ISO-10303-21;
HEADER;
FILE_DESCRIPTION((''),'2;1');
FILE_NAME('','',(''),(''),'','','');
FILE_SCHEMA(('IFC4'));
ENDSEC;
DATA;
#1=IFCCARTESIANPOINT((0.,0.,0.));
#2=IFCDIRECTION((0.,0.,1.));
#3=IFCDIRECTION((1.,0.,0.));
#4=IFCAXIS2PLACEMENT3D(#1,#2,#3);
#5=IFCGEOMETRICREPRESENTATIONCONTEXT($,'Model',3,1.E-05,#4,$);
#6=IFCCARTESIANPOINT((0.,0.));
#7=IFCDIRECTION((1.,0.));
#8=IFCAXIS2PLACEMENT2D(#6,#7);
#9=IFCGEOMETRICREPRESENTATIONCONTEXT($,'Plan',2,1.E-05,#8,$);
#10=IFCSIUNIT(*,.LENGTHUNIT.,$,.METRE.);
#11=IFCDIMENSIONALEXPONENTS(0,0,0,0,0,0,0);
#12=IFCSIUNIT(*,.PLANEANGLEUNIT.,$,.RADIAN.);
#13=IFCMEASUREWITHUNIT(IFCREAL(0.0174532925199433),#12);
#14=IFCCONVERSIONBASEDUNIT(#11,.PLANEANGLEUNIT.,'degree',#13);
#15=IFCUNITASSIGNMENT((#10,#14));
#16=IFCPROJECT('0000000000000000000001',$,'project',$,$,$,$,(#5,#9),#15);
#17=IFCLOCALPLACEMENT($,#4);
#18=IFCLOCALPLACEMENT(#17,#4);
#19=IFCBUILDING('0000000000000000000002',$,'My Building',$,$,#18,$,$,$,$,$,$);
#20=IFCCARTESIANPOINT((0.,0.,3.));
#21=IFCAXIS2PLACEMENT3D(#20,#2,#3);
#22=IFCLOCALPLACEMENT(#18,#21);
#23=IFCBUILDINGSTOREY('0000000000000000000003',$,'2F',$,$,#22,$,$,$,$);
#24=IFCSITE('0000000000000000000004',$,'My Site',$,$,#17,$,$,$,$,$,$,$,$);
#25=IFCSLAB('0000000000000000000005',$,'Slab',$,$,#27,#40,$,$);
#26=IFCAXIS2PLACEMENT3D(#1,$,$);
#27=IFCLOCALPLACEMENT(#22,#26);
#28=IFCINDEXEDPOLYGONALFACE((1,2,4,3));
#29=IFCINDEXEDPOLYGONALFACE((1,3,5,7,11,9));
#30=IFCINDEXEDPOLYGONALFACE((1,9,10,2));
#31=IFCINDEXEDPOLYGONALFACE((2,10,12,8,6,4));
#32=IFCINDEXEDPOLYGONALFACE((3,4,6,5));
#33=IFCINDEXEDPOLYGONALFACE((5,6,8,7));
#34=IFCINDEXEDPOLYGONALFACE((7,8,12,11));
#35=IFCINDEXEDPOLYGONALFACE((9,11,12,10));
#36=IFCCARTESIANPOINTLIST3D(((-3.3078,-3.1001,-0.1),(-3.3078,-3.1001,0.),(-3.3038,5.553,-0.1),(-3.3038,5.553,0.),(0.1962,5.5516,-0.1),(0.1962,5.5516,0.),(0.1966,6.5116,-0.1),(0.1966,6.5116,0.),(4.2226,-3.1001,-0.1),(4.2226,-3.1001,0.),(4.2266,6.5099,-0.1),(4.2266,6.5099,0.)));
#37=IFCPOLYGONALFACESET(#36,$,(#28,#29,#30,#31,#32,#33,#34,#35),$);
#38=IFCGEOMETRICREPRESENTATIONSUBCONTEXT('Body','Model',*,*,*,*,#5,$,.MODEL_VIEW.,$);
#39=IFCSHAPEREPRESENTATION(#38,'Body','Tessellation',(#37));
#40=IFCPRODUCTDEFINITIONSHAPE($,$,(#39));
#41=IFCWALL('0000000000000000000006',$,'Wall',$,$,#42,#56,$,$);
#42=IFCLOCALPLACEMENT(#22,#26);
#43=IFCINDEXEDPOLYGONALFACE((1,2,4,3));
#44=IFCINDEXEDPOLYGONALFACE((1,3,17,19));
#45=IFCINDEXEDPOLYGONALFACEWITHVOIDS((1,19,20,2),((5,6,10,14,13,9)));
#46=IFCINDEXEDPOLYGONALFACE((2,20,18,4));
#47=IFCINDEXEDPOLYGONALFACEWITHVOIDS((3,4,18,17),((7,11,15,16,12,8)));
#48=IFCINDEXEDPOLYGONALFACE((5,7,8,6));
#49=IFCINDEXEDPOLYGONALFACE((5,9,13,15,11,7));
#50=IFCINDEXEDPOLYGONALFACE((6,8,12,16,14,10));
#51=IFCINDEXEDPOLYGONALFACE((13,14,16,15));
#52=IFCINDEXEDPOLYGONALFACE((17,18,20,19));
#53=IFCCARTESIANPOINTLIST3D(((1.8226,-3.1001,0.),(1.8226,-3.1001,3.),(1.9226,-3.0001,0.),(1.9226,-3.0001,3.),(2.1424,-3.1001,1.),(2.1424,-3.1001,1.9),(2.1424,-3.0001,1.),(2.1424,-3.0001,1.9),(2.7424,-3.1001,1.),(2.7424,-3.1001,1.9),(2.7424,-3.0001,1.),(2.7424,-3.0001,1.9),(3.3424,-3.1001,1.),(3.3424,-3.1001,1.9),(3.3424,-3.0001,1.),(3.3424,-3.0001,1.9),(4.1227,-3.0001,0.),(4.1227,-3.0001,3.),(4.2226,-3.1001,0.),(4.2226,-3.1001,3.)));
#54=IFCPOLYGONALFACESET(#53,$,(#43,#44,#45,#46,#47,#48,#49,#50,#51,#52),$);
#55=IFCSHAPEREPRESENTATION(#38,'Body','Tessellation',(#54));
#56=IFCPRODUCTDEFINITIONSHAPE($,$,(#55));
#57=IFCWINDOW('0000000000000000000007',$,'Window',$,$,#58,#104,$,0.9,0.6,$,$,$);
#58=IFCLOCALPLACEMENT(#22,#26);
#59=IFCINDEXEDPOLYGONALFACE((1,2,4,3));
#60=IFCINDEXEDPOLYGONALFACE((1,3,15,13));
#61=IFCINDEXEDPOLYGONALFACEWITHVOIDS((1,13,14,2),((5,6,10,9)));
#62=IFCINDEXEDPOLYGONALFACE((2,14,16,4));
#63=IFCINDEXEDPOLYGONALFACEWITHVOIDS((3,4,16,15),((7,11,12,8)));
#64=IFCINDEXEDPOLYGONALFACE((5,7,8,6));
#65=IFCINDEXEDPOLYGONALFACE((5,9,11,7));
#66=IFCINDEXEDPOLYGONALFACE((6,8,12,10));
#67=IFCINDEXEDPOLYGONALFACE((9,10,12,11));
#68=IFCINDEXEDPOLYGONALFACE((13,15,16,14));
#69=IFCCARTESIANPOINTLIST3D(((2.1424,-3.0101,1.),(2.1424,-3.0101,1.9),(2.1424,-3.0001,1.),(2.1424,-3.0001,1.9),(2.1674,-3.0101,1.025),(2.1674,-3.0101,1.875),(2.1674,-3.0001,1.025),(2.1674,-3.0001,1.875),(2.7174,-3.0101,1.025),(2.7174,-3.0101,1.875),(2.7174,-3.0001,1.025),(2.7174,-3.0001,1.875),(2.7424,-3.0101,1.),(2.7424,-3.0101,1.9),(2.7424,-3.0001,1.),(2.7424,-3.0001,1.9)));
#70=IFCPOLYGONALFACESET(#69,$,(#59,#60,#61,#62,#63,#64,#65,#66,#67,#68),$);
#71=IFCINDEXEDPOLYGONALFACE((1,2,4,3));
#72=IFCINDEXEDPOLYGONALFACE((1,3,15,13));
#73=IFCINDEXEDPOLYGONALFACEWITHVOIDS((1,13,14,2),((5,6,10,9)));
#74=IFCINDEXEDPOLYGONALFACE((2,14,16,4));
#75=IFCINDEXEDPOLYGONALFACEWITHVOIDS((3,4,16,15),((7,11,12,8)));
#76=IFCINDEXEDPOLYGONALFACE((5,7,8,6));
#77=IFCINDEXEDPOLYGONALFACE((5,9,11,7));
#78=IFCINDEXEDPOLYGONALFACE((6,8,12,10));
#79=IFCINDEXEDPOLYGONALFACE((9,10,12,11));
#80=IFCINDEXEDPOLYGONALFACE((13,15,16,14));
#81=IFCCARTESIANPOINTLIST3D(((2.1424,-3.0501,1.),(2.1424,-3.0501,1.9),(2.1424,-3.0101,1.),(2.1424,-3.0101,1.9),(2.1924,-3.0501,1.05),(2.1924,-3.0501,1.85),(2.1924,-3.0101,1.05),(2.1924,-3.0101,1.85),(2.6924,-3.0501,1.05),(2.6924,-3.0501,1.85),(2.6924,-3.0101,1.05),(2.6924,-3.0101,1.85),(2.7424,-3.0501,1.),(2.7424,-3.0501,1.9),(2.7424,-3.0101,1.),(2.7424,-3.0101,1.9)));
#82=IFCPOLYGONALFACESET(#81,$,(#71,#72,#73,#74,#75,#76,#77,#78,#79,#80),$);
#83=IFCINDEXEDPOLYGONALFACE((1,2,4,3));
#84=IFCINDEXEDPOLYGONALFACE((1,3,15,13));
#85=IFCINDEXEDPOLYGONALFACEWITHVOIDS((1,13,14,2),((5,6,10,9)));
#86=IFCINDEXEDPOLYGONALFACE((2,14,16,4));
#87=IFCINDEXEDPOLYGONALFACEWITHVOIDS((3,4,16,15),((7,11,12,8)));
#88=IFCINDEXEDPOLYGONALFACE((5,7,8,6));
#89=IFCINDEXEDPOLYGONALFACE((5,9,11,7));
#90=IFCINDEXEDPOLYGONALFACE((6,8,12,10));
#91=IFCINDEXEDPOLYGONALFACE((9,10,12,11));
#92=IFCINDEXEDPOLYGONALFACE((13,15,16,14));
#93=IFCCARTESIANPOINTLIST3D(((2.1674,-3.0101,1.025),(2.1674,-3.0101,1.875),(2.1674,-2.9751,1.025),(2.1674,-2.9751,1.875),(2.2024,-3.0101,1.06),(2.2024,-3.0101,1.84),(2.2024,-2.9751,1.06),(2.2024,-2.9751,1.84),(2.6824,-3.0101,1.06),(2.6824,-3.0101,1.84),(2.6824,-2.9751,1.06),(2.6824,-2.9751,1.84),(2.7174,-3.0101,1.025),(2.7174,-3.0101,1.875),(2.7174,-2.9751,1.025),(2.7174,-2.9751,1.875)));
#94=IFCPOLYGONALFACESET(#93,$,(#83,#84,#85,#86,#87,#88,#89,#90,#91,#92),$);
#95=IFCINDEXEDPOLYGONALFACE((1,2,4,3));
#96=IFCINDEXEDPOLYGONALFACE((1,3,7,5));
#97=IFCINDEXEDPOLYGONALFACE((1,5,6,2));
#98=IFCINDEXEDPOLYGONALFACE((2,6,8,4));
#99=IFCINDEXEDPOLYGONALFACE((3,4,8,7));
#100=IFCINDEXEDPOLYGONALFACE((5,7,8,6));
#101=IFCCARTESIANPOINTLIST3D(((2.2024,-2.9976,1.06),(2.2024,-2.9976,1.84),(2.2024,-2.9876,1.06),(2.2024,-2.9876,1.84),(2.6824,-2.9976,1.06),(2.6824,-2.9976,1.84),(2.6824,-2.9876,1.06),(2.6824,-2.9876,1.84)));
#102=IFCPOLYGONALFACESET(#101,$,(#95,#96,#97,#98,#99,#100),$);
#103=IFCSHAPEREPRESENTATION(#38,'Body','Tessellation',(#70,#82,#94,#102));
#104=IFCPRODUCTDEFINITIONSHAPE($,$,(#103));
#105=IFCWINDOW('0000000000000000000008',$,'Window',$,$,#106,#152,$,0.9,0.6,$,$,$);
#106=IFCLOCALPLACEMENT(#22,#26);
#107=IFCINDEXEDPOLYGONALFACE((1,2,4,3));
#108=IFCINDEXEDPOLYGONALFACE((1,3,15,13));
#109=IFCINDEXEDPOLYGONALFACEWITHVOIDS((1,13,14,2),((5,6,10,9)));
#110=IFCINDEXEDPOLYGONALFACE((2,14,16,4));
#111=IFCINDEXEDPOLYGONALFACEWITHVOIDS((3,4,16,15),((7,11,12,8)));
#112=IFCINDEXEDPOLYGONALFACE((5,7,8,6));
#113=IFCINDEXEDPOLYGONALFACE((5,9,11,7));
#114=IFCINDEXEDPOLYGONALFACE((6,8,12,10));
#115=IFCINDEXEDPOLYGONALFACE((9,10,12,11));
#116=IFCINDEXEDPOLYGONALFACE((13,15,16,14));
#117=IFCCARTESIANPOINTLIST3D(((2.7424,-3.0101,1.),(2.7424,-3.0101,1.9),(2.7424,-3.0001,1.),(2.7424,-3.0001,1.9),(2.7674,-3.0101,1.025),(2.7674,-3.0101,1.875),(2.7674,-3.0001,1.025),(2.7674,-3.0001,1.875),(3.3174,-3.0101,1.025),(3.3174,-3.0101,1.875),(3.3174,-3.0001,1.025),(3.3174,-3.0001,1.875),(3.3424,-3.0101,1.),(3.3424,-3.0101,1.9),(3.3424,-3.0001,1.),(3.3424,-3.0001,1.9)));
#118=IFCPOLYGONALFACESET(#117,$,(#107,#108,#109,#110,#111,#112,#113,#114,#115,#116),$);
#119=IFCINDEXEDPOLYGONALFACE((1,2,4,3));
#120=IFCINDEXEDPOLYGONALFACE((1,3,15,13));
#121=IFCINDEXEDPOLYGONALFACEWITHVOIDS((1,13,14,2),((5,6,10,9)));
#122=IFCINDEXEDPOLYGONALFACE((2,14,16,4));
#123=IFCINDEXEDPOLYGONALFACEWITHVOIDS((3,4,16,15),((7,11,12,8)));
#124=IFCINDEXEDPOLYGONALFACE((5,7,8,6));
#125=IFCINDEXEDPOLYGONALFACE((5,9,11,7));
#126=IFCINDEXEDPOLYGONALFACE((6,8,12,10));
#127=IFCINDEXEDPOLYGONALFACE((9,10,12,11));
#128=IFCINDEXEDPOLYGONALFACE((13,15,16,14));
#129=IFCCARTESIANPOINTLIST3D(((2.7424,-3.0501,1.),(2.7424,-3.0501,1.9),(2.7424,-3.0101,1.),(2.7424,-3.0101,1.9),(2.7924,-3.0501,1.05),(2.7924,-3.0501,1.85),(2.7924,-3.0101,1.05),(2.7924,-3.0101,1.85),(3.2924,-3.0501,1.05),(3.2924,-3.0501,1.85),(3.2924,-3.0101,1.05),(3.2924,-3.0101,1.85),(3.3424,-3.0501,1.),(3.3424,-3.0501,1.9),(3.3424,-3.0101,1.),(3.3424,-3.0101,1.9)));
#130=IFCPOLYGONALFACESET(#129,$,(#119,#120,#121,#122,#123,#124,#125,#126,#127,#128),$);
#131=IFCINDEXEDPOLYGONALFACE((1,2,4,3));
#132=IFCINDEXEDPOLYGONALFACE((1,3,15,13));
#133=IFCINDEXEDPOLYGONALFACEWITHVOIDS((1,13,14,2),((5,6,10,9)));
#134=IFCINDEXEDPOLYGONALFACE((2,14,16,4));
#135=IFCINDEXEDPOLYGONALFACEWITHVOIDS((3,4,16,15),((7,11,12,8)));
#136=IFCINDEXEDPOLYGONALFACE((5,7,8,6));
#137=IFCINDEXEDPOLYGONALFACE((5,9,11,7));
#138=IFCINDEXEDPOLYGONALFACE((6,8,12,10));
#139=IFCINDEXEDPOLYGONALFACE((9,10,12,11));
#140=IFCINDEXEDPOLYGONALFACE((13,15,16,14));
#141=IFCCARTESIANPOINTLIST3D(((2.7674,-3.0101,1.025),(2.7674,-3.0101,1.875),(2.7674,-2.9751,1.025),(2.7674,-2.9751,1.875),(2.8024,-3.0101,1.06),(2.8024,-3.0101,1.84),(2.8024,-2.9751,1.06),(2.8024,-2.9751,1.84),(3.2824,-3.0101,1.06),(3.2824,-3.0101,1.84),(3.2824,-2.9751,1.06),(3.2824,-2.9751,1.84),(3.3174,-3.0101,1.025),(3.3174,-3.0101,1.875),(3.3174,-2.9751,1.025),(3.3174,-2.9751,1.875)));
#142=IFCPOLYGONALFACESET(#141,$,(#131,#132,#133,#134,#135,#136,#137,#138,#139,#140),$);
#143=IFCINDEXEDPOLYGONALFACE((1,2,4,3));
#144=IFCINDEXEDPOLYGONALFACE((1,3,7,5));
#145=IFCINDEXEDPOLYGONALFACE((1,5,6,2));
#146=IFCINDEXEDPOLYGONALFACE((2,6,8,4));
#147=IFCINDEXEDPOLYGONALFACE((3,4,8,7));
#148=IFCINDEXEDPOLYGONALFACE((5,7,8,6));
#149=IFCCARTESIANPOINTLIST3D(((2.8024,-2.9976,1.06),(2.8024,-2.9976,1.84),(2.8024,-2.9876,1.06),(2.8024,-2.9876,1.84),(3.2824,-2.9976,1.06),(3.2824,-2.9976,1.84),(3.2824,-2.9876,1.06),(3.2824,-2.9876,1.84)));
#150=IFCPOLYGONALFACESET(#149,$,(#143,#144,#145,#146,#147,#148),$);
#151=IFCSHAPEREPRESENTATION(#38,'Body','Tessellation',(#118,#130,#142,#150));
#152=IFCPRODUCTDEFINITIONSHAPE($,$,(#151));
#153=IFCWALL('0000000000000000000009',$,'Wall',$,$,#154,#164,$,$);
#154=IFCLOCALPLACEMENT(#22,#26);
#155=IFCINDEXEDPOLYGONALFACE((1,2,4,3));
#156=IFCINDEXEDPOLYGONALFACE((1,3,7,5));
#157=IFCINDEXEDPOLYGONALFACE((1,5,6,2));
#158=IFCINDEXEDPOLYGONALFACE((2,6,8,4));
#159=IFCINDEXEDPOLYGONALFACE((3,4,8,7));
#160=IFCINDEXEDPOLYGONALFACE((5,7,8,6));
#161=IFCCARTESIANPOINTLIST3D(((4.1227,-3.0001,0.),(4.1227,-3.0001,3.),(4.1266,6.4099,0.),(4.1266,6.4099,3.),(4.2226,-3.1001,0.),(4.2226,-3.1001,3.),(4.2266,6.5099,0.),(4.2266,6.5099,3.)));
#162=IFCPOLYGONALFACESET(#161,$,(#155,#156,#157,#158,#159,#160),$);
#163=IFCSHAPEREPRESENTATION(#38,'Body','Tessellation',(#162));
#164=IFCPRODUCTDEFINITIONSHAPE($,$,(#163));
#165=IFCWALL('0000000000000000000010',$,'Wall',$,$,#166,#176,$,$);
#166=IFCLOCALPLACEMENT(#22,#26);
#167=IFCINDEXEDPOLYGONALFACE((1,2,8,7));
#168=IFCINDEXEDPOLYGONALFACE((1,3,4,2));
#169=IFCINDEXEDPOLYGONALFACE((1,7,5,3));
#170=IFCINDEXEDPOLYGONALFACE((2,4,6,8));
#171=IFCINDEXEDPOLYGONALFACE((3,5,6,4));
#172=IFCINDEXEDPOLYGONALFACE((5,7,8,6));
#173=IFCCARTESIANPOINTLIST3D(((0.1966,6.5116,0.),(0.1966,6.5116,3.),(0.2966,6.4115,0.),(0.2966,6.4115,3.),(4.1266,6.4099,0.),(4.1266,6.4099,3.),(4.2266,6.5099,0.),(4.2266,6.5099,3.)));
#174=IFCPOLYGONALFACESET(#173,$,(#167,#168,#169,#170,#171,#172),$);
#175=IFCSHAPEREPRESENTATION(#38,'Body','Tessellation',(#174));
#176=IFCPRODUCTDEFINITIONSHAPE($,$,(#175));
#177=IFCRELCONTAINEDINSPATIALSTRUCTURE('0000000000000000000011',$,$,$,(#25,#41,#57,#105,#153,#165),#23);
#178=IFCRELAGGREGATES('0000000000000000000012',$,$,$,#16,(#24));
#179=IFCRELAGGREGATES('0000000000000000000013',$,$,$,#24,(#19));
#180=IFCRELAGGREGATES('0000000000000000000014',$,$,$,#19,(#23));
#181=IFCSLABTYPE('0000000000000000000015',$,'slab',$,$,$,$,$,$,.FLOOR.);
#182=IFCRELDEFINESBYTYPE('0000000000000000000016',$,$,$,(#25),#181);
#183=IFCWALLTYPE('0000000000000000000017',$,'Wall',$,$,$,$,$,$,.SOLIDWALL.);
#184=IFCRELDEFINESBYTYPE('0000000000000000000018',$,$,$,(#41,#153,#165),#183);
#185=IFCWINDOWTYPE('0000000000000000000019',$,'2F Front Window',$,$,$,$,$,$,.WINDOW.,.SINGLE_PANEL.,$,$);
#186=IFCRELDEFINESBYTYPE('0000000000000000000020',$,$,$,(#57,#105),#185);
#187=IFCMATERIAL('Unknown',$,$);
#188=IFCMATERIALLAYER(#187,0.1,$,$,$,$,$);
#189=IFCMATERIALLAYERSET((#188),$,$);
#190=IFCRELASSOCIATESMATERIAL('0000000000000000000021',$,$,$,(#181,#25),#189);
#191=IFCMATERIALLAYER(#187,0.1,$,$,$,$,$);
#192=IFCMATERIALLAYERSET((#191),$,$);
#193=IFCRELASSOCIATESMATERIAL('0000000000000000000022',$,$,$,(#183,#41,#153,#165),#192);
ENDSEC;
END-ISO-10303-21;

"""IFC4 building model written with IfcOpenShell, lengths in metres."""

from ifc_helpers import new_model, entity, si_unit, converted_unit, frame, origin_with_axes, origin_2d_with_axis, place, context, subcontext, project, spatial, line, indexed_curve, outline, extrude, shape, source, transform, mapped, material, layer, layer_set, layer_usage, type_object, type_shapes, element, fill, save


model = new_model("IFC4")

# Units and contexts
model_context = context("Model", 3, precision=1e-05, world=origin_with_axes())
plan_context = context("Plan", 2, precision=1e-05, world=origin_2d_with_axis())
body_context_1 = subcontext(model_context, "Body", "Model", "MODEL_VIEW")
body_context_2 = subcontext(plan_context, "Body", "Plan", "PLAN_VIEW")
ifc_project = project(units=[si_unit("LENGTHUNIT", "METRE"), converted_unit("PLANEANGLEUNIT", "degree", entity("IfcReal", 0.0174532925199433), si_unit("PLANEANGLEUNIT", "RADIAN"), dimensions=[0, 0, 0, 0, 0, 0, 0])], contexts=[model_context, plan_context])

# Site, building, storey
site_placement = place(None, origin_with_axes())
site = spatial("IfcSite", under=ifc_project, at=site_placement, Name="My Site")
building_placement = place(site_placement, origin_with_axes())
building = spatial("IfcBuilding", under=site, at=building_placement, Name="My Building")
storey_placement = place(building_placement, frame((0.0, 0.0, 3.0), z_axis=(0.0, 0.0, 1.0), x_axis=(1.0, 0.0, 0.0)))
storey = spatial("IfcBuildingStorey", under=building, at=storey_placement, Name="2F")

# Slab
ifc_material = material(Name="Unknown")
ifc_layer_1 = layer(ifc_material, 0.1)
ifc_layer_set_1 = layer_set([ifc_layer_1])
ifc_layer_usage_1 = layer_usage(ifc_layer_set_1, "AXIS3", "POSITIVE", -0.1)
slab_type = type_object("IfcSlabType", Name="slab", PredefinedType="FLOOR", material=ifc_layer_set_1)
slab_placement = place(storey_placement, frame((-3.3078, -3.1001, 0.0), z_axis=(0.0, 0.0, 1.0), x_axis=(1.0, 0.0, 0.0)))
element("IfcSlab", 1, at=slab_placement, inside=storey, type_object=slab_type, material=ifc_layer_usage_1, Name="Slab", context=body_context_1, shape_type="SweptSolid", body=[
    extrude(outline(indexed_curve([(0.0, 0.0), (7.5304, 0.0), (7.5344, 9.61), (3.5044, 9.6117), (3.504, 8.6517), (0.004, 8.6531), (0.0, 0.0)])), frame((0.0, 0.0, -0.1), z_axis=(0.0, 0.0, 1.0), x_axis=(1.0, 0.0, 0.0)), (0.0, 0.0, 1.0), 0.1),
])

# Wall, openings, windows
ifc_layer_2 = layer(ifc_material, 0.1)
ifc_layer_set_2 = layer_set([ifc_layer_2])
ifc_layer_usage_2 = layer_usage(ifc_layer_set_2, "AXIS2", "POSITIVE", 0.0)
wall_type = type_object("IfcWallType", Name="Wall", PredefinedType="SOLIDWALL", material=ifc_layer_set_2)
wall_1_placement = place(storey_placement, frame((1.8226, -3.1001, 0.0), z_axis=(0.0, 0.0, 1.0), x_axis=(1.0, 0.0, 0.0)))
wall_1 = element("IfcWall", 2, at=wall_1_placement, inside=storey, type_object=wall_type, material=ifc_layer_usage_2, Name="Wall", context=body_context_1, shape_type="SweptSolid", body=[
    extrude(outline(indexed_curve([(0.0, 0.0), (0.1, 0.1), (2.3, 0.1), (2.4, 0.0)], segments=[line(1, 2, 3, 4, 1)])), origin_with_axes(), (0.0, 0.0, 1.0), 3.0),
])
shared_shape_1 = source(origin_with_axes(), body_context_1, "Body", "SweptSolid", [
    extrude(outline(indexed_curve([(0.0, 0.0), (0.6, 0.0), (0.6, 0.9), (0.0, 0.9)], segments=[line(1, 2, 3, 4, 1)])), frame((0.0, -0.6, 0.0), z_axis=(0.0, -1.0, 0.0), x_axis=(1.0, 0.0, 0.0)), (0.0, 0.0, -1.0), 1.2),
])
opening_1_placement = place(wall_1_placement, frame((0.3197, 0.0, 1.0), z_axis=(0.0, 0.0, 1.0), x_axis=(1.0, 0.0, 0.0)))
opening_1 = element("IfcOpeningElement", 3, at=opening_1_placement, cuts=wall_1, PredefinedType="OPENING", context=body_context_1, shape_type="MappedRepresentation", body=[
    mapped(shared_shape_1, transform((0.0, 0.0, 0.0), x_axis=(1.0, 0.0, 0.0), y_axis=(0.0, 1.0, 0.0), z_axis=(0.0, 0.0, 1.0), scale=1.0)),
])
opening_2_placement = place(wall_1_placement, frame((0.9197, 0.0, 1.0), z_axis=(0.0, 0.0, 1.0), x_axis=(1.0, 0.0, 0.0)))
opening_2 = element("IfcOpeningElement", 4, at=opening_2_placement, cuts=wall_1, PredefinedType="OPENING", context=body_context_1, shape_type="MappedRepresentation", body=[
    mapped(shared_shape_1, transform((0.0, 0.0, 0.0), x_axis=(1.0, 0.0, 0.0), y_axis=(0.0, 1.0, 0.0), z_axis=(0.0, 0.0, 1.0), scale=1.0)),
])
window_type_1 = type_object("IfcWindowType", Name="2F Front Window", PartitioningType="SINGLE_PANEL", PredefinedType="WINDOW")
shared_shape_2 = source(origin_with_axes(), body_context_1, "Body", "SweptSolid", [
    extrude(outline(indexed_curve([(0.0, 0.0), (0.6, 0.0), (0.6, 0.9), (0.0, 0.9)], segments=[line(1, 2, 3, 4, 1)]), holes=[indexed_curve([(0.025, 0.025), (0.575, 0.025), (0.575, 0.875), (0.025, 0.875)], segments=[line(1, 2, 3, 4, 1)])]), frame((0.0, 0.09, 0.0), z_axis=(0.0, -1.0, 0.0), x_axis=(1.0, 0.0, 0.0)), (0.0, 0.0, -1.0), 0.01),
    extrude(outline(indexed_curve([(0.0, 0.0), (0.6, 0.0), (0.6, 0.9), (0.0, 0.9)], segments=[line(1, 2, 3, 4, 1)]), holes=[indexed_curve([(0.05, 0.05), (0.55, 0.05), (0.55, 0.85), (0.05, 0.85)], segments=[line(1, 2, 3, 4, 1)])]), frame((0.0, 0.05, 0.0), z_axis=(0.0, -1.0, 0.0), x_axis=(1.0, 0.0, 0.0)), (0.0, 0.0, -1.0), 0.04),
    extrude(outline(indexed_curve([(0.0, 0.0), (0.55, 0.0), (0.55, 0.85), (0.0, 0.85)], segments=[line(1, 2, 3, 4, 1)]), holes=[indexed_curve([(0.035, 0.035), (0.515, 0.035), (0.515, 0.815), (0.035, 0.815)], segments=[line(1, 2, 3, 4, 1)])]), frame((0.025, 0.09, 0.025), z_axis=(0.0, -1.0, 0.0), x_axis=(1.0, 0.0, 0.0)), (0.0, 0.0, -1.0), 0.035),
    extrude(outline(indexed_curve([(0.035, 0.035), (0.515, 0.035), (0.515, 0.815), (0.035, 0.815)], segments=[line(1, 2, 3, 4, 1)])), frame((0.025, 0.1025, 0.025), z_axis=(0.0, -1.0, 0.0), x_axis=(1.0, 0.0, 0.0)), (0.0, 0.0, -1.0), 0.01),
])
shared_shape_3 = source(origin_with_axes(), body_context_2, "Body", "Curve2D", [
    entity("IfcIndexedPolyCurve", entity("IfcCartesianPointList2D", [[0.05, 0.05], [0.55, 0.05]])),
    entity("IfcIndexedPolyCurve", entity("IfcCartesianPointList2D", [[0.0, 0.1], [0.025, 0.1], [0.025, 0.09], [0.05, 0.09], [0.05, 0.05], [0.0, 0.05]]), [entity("IfcLineIndex", [1, 2, 3, 4, 5, 6, 1])]),
    entity("IfcIndexedPolyCurve", entity("IfcCartesianPointList2D", [[0.6, 0.1], [0.575, 0.1], [0.575, 0.09], [0.55, 0.09], [0.55, 0.05], [0.6, 0.05]]), [entity("IfcLineIndex", [1, 2, 3, 4, 5, 6, 1])]),
    entity("IfcIndexedPolyCurve", entity("IfcCartesianPointList2D", [[0.025, 0.09], [0.06, 0.09], [0.06, 0.125], [0.025, 0.125]]), [entity("IfcLineIndex", [1, 2, 3, 4, 1])]),
    entity("IfcIndexedPolyCurve", entity("IfcCartesianPointList2D", [[0.575, 0.09], [0.54, 0.09], [0.54, 0.125], [0.575, 0.125]]), [entity("IfcLineIndex", [1, 2, 3, 4, 1])]),
    entity("IfcIndexedPolyCurve", entity("IfcCartesianPointList2D", [[0.06, 0.09], [0.54, 0.09]])),
    entity("IfcIndexedPolyCurve", entity("IfcCartesianPointList2D", [[0.06, 0.125], [0.54, 0.125]])),
    entity("IfcIndexedPolyCurve", entity("IfcCartesianPointList2D", [[0.06, 0.1075], [0.54, 0.1075]])),
])
type_shapes(window_type_1, [shared_shape_2, shared_shape_3])
window_1_placement = place(opening_1_placement, origin_with_axes())
window_1 = element("IfcWindow", 5, at=window_1_placement, inside=storey, type_object=window_type_1, Name="Window", OverallHeight=0.9, OverallWidth=0.6, shapes=[
    shape(body_context_1, "Body", "MappedRepresentation", [mapped(shared_shape_2, transform((0.0, 0.0, 0.0), x_axis=(1.0, 0.0, 0.0), y_axis=(0.0, 1.0, 0.0), z_axis=(0.0, 0.0, 1.0), scale=1.0))]),
    shape(body_context_2, "Body", "MappedRepresentation", [mapped(shared_shape_3, transform((0.0, 0.0, 0.0), x_axis=(1.0, 0.0, 0.0), y_axis=(0.0, 1.0, 0.0), z_axis=(0.0, 0.0, 1.0), scale=1.0))]),
])
fill(opening_1, window_1)
window_2_placement = place(opening_2_placement, origin_with_axes())
window_2 = element("IfcWindow", 6, at=window_2_placement, inside=storey, type_object=window_type_1, Name="Window", OverallHeight=0.9, OverallWidth=0.6, shapes=[
    shape(body_context_1, "Body", "MappedRepresentation", [mapped(shared_shape_2, transform((0.0, 0.0, 0.0), x_axis=(1.0, 0.0, 0.0), y_axis=(0.0, 1.0, 0.0), z_axis=(0.0, 0.0, 1.0), scale=1.0))]),
    shape(body_context_2, "Body", "MappedRepresentation", [mapped(shared_shape_3, transform((0.0, 0.0, 0.0), x_axis=(1.0, 0.0, 0.0), y_axis=(0.0, 1.0, 0.0), z_axis=(0.0, 0.0, 1.0), scale=1.0))]),
])
fill(opening_2, window_2)

# Walls
ifc_layer_usage_3 = layer_usage(ifc_layer_set_2, "AXIS2", "POSITIVE", 0.0)
wall_2_placement = place(storey_placement, frame((4.2226, -3.1001, 0.0), z_axis=(0.0, 0.0, 1.0), x_axis=(0.000415, 1.0, 0.0)))
element("IfcWall", 7, at=wall_2_placement, inside=storey, type_object=wall_type, material=ifc_layer_usage_3, Name="Wall", context=body_context_1, shape_type="SweptSolid", body=[
    extrude(outline(indexed_curve([(0.0, 0.0), (0.1, 0.1), (9.51, 0.1), (9.61, 0.0)], segments=[line(1, 2, 3, 4, 1)])), origin_with_axes(), (0.0, 0.0, 1.0), 3.0),
])
ifc_layer_usage_4 = layer_usage(ifc_layer_set_2, "AXIS2", "POSITIVE", 0.0)
wall_3_placement = place(storey_placement, frame((4.2266, 6.5099, 0.0), z_axis=(0.0, 0.0, 1.0), x_axis=(-1.0, 0.000415, 0.0)))
element("IfcWall", 8, at=wall_3_placement, inside=storey, type_object=wall_type, material=ifc_layer_usage_4, Name="Wall", context=body_context_1, shape_type="SweptSolid", body=[
    extrude(outline(indexed_curve([(0.0, 0.0), (0.1, 0.1), (3.93, 0.1), (4.03, 0.0)], segments=[line(1, 2, 3, 4, 1)])), origin_with_axes(), (0.0, 0.0, 1.0), 3.0),
])

save(model, "model.ifc")
